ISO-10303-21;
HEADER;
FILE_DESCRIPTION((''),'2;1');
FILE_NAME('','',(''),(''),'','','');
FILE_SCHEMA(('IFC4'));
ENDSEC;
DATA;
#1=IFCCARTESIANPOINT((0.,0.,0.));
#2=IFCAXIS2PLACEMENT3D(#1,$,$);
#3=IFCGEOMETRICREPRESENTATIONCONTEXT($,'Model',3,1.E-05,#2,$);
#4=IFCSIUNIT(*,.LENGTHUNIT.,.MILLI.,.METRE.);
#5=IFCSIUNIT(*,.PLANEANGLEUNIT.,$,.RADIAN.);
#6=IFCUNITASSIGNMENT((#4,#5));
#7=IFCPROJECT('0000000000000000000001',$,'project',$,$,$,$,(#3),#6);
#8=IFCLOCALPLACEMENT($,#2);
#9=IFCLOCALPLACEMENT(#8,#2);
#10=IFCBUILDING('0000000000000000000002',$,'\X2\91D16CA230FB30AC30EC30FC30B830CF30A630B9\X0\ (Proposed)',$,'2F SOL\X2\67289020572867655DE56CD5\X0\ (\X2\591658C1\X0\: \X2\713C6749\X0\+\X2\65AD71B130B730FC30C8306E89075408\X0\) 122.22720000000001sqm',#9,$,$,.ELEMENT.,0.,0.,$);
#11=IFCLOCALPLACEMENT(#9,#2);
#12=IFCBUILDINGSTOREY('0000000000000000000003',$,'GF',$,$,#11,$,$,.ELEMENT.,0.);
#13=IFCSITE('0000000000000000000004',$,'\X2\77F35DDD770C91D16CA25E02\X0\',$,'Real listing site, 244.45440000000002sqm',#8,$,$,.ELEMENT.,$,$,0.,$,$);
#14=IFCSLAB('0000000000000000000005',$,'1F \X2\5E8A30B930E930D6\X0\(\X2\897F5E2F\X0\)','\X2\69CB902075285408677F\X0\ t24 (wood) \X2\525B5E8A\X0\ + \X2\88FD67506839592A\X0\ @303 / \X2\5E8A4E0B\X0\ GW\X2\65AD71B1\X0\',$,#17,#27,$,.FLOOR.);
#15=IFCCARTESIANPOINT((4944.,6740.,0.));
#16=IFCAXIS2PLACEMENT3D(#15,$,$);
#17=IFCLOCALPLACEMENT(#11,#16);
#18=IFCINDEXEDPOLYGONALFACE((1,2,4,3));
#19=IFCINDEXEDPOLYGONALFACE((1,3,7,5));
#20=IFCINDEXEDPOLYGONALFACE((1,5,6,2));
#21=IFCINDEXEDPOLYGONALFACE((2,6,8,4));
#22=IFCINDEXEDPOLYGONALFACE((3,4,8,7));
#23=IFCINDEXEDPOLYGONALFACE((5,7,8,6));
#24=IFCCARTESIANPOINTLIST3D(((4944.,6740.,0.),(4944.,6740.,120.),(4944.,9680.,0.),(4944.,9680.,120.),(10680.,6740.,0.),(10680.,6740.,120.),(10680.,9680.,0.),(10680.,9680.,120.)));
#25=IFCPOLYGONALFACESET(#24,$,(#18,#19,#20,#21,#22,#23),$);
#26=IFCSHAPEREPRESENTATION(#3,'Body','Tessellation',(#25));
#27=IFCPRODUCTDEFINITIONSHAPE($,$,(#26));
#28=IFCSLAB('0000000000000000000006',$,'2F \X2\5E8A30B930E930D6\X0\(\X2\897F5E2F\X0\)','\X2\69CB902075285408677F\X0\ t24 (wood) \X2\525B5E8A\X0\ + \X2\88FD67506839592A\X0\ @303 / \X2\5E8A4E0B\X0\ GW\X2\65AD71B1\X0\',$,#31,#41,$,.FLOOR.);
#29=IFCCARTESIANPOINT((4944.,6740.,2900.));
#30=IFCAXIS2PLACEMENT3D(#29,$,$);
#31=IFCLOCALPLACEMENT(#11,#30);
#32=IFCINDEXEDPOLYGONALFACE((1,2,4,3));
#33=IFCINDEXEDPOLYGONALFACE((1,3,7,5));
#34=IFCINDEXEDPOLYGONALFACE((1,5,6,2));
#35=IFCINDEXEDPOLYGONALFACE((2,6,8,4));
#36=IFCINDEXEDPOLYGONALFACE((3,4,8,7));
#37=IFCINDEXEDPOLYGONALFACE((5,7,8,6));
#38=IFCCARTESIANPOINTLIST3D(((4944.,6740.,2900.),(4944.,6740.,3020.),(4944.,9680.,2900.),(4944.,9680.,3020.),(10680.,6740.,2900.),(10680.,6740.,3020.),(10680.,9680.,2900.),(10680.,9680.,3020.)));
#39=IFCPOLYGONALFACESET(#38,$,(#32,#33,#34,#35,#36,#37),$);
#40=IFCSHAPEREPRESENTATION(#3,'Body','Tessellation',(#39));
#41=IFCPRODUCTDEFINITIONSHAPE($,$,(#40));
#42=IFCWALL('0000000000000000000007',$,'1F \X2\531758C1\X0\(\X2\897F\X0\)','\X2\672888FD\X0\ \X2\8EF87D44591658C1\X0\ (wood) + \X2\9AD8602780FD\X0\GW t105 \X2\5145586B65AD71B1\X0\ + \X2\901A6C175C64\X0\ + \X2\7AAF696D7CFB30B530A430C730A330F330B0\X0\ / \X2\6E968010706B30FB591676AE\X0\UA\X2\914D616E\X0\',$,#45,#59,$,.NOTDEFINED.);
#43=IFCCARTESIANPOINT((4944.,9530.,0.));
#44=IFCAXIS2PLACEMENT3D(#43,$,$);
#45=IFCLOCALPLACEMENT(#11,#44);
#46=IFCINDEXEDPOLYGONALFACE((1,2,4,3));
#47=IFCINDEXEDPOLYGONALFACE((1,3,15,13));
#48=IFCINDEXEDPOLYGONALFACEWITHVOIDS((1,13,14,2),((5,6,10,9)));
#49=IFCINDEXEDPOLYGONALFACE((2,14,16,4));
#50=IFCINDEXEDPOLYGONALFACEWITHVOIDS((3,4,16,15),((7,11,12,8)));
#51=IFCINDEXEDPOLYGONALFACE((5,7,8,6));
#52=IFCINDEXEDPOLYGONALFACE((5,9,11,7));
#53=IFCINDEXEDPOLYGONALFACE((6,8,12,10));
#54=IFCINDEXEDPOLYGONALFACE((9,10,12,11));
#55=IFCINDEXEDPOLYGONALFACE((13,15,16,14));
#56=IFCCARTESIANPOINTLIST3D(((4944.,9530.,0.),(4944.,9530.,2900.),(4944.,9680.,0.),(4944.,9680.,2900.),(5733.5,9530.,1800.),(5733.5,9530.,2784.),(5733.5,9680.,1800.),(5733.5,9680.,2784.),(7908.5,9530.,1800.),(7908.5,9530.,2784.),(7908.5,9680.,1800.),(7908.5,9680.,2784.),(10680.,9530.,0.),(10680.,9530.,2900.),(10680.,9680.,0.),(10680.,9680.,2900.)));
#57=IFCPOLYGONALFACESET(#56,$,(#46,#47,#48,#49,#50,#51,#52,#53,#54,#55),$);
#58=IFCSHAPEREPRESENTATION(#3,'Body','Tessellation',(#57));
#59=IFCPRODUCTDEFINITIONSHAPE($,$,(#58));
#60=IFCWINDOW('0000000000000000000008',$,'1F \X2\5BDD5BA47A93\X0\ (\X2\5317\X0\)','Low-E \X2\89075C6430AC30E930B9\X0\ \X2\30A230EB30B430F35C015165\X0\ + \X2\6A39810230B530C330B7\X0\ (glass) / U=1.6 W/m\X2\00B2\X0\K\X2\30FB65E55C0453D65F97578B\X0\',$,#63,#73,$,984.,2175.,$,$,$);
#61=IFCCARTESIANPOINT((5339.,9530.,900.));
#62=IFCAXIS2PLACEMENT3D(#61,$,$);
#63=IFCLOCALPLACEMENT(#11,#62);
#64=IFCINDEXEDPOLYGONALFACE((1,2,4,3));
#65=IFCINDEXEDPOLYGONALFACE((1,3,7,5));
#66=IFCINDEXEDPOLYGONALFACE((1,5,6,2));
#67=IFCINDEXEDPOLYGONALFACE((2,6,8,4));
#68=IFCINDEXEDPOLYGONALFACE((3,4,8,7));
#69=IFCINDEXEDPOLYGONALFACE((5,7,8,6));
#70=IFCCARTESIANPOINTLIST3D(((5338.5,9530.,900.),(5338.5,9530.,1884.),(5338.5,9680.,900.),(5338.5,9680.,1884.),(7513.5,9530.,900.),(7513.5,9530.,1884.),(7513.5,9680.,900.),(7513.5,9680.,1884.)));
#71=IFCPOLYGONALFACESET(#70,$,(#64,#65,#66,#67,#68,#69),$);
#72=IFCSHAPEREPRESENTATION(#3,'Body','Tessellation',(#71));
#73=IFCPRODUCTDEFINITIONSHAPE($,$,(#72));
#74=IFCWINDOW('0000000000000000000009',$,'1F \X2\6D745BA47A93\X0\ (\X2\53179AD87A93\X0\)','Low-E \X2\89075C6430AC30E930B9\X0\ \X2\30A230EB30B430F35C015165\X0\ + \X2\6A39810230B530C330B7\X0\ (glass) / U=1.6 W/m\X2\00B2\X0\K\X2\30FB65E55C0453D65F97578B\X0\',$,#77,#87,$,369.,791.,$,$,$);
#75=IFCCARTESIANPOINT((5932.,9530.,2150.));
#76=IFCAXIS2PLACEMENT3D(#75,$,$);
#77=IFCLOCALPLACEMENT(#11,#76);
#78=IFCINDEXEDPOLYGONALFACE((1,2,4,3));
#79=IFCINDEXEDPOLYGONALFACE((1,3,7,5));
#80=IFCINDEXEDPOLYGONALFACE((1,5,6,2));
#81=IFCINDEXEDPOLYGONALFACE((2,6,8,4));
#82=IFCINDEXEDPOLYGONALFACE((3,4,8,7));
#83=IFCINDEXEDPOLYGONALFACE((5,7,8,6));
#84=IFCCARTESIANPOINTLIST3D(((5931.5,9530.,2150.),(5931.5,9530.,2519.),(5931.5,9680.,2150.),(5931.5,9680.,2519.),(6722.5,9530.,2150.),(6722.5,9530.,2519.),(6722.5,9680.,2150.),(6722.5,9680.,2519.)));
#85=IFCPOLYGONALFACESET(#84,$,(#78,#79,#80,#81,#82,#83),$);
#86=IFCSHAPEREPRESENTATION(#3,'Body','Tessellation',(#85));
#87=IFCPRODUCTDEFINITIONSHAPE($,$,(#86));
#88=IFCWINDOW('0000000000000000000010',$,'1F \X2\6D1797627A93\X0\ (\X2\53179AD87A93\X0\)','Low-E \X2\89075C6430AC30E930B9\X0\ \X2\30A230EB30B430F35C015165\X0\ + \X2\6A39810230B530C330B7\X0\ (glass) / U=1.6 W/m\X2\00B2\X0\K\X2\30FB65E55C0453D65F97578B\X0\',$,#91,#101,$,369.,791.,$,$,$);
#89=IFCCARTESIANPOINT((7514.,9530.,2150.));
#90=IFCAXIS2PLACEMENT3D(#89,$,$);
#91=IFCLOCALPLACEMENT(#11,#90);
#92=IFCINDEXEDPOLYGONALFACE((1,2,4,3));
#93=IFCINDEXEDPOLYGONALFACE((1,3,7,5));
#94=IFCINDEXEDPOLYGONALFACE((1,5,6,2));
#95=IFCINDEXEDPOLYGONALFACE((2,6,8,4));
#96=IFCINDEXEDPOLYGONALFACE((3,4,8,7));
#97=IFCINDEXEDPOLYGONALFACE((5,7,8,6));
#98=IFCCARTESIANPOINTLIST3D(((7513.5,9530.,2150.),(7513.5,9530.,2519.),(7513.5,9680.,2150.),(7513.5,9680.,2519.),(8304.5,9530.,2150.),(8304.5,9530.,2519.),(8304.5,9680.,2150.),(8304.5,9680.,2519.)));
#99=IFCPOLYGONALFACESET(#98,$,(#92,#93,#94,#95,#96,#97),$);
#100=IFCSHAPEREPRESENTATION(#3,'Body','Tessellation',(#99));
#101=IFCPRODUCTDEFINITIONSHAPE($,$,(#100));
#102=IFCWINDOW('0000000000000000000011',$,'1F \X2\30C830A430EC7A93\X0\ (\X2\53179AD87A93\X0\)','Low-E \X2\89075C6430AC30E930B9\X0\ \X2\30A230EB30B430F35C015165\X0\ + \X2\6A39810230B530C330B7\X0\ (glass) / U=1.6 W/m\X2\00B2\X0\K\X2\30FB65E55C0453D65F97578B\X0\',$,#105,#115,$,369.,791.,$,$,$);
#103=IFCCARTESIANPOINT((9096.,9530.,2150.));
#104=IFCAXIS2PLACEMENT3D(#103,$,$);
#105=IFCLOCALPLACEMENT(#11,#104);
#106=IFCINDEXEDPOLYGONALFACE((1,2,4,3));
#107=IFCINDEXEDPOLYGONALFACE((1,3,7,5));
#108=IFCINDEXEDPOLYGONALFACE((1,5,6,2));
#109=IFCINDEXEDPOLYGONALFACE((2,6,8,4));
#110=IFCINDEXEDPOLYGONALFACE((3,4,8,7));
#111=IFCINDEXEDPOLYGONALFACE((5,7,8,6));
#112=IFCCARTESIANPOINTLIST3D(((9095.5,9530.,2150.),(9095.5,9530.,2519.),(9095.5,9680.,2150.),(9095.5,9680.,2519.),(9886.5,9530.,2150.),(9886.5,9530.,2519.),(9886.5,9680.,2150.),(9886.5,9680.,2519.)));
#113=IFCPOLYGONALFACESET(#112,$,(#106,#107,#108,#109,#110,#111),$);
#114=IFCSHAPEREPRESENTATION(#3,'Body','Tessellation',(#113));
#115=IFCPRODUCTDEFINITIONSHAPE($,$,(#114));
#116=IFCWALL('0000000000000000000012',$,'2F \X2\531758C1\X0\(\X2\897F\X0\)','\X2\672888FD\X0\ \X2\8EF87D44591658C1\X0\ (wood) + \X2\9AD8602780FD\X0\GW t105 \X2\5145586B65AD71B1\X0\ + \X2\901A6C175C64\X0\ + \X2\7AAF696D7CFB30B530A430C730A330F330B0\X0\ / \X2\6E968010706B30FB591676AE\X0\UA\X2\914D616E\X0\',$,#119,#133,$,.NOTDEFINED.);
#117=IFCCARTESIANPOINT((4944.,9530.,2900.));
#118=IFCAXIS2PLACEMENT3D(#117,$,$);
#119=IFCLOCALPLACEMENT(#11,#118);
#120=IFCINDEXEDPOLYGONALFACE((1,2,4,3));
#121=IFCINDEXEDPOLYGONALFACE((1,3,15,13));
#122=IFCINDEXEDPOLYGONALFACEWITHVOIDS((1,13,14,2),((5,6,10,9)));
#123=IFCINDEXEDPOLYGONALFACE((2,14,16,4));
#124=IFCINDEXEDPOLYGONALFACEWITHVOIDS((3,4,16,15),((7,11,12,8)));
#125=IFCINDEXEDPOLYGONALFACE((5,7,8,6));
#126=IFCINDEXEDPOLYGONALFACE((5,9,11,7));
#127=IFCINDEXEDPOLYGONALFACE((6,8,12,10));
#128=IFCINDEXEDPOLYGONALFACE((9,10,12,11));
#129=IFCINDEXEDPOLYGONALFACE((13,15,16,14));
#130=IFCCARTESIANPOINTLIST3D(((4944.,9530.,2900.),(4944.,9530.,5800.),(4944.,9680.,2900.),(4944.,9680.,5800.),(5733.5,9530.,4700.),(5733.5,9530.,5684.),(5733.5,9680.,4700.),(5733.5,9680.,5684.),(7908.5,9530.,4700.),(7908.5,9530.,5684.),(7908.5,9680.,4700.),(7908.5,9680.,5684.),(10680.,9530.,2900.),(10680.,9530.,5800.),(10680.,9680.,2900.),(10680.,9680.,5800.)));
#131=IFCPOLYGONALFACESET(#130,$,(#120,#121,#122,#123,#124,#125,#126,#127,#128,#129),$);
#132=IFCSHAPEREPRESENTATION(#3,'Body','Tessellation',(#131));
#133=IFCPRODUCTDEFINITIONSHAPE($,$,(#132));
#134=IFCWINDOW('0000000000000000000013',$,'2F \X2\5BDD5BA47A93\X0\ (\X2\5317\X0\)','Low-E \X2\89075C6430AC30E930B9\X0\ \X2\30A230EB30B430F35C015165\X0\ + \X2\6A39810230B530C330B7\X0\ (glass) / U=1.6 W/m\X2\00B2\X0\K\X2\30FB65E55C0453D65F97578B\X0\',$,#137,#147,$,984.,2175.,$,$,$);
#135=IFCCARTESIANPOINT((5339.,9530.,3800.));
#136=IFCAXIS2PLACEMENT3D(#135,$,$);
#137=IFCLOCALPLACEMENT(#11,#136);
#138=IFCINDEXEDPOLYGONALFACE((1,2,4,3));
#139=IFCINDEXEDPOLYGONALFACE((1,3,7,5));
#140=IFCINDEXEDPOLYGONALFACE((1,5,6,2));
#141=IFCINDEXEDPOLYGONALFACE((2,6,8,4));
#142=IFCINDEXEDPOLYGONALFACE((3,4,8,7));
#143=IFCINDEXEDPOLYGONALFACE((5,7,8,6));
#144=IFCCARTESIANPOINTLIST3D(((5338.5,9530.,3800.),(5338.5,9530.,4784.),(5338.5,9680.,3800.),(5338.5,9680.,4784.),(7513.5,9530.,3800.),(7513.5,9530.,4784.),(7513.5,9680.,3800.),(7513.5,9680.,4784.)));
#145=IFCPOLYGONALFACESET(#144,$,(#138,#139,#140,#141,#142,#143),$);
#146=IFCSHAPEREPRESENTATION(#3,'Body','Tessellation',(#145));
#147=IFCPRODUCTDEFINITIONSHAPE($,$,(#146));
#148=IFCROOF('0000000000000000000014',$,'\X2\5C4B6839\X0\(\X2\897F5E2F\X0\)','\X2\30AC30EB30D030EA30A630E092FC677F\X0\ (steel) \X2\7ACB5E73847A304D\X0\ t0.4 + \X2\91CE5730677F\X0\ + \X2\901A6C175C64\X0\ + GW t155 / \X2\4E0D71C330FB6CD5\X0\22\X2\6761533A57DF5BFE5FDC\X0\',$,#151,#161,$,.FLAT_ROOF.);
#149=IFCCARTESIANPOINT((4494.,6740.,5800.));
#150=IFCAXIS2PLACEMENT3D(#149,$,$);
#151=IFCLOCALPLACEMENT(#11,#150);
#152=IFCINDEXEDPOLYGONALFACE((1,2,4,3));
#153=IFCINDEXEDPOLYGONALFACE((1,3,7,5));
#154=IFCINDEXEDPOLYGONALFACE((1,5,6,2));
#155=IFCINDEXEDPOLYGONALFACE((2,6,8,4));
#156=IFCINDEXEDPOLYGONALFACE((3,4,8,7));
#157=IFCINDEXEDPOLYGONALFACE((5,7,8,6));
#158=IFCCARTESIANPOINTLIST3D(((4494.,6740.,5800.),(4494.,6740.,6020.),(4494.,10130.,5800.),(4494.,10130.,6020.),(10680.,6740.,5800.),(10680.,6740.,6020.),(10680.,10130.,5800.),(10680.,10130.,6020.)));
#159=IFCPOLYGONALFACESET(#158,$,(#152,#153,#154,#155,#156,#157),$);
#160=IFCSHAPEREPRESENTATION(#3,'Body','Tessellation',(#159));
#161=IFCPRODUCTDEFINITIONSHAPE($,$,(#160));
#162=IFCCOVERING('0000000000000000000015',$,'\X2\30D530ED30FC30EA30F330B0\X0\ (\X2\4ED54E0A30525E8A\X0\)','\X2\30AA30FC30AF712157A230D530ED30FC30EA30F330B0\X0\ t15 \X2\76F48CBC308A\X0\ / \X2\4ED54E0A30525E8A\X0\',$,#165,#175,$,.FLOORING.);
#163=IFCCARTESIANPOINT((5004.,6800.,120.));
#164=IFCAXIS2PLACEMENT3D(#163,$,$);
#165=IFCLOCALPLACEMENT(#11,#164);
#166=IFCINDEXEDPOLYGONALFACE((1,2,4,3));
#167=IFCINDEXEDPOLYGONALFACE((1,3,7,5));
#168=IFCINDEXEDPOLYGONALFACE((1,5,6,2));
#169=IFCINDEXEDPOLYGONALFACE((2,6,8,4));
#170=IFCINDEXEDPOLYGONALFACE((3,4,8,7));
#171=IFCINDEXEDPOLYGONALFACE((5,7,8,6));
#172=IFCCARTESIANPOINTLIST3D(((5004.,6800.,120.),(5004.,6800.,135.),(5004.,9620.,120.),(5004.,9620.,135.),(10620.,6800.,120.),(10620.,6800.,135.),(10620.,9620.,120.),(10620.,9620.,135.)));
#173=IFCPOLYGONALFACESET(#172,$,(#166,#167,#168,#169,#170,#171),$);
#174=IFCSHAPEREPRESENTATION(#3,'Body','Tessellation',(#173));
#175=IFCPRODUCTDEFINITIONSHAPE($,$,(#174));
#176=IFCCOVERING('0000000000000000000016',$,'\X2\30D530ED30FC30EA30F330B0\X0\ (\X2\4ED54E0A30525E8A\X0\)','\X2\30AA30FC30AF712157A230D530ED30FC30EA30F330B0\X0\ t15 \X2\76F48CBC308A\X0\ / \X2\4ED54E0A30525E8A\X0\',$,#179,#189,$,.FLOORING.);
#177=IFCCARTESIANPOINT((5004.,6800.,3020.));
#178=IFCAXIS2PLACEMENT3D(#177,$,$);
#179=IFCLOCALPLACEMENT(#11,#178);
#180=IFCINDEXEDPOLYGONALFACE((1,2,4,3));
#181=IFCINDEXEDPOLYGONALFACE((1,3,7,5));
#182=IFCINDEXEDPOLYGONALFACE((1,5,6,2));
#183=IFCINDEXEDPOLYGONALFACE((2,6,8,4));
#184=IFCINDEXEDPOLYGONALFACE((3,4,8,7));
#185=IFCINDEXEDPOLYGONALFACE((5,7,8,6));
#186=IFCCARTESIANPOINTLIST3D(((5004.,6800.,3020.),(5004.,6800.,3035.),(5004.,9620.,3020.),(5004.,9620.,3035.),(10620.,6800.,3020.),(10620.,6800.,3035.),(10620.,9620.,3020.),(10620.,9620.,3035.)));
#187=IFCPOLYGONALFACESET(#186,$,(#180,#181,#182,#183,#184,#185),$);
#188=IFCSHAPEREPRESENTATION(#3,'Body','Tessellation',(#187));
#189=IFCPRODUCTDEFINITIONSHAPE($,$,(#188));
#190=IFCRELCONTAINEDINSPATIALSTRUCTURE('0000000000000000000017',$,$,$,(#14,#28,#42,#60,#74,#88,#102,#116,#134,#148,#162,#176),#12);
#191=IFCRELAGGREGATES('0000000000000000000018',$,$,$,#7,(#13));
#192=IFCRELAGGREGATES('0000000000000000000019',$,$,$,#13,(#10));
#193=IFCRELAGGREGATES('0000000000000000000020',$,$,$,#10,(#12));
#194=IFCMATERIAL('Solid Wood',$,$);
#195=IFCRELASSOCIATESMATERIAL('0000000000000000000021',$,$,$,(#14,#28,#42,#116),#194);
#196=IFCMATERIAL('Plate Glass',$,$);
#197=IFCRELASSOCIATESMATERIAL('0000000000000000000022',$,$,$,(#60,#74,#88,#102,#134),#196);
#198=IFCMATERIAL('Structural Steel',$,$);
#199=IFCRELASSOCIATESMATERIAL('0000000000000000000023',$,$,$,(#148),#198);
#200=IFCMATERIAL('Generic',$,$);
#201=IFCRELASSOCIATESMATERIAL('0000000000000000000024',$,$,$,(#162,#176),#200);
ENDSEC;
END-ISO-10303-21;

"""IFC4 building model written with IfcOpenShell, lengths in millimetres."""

from ifc_helpers import new_model, si_unit, frame, frame_2d, origin, place, context, project, spatial, rectangle, extrude, material, element, fill, save


model = new_model("IFC4")

# Units and contexts
model_context = context("Model", 3, precision=1e-05, world=origin())
ifc_project = project(units=[si_unit("LENGTHUNIT", "METRE", prefix="MILLI"), si_unit("PLANEANGLEUNIT", "RADIAN")], contexts=[model_context])

# Site, building, storey
site_placement = place(None, origin())
site = spatial("IfcSite", under=ifc_project, at=site_placement, Name="石川県金沢市", ObjectType="Real listing site, 244.45440000000002sqm", CompositionType="ELEMENT", RefElevation=0.0)
building_placement = place(site_placement, origin())
building = spatial("IfcBuilding", under=site, at=building_placement, Name="金沢・ガレージハウス (Proposed)", ObjectType="2F SOL木造在来工法 (外壁: 焼杉+断熱シートの複合) 122.22720000000001sqm", CompositionType="ELEMENT", ElevationOfRefHeight=0.0, ElevationOfTerrain=0.0)
storey_placement = place(building_placement, origin())
storey = spatial("IfcBuildingStorey", under=building, at=storey_placement, Name="GF", CompositionType="ELEMENT", Elevation=0.0)

# Slabs
ifc_material_1 = material(Name="Solid Wood")
slab_1_placement = place(storey_placement, frame((4944.0, 6740.0, 0.0)))
element("IfcSlab", 1, at=slab_1_placement, inside=storey, material=ifc_material_1, Name="1F 床スラブ(西帯)", Description="構造用合板 t24 (wood) 剛床 + 製材根太 @303 / 床下 GW断熱", PredefinedType="FLOOR", context=model_context, shape_type="SweptSolid", body=[
    extrude(rectangle(XDim=5736.0, YDim=2940.0, at=frame_2d((2868.0, 1470.0))), frame((4944.0, 6740.0, 0.0)), (0.0, 0.0, 1.0), 120.0),
])
slab_2_placement = place(storey_placement, frame((4944.0, 6740.0, 2900.0)))
element("IfcSlab", 2, at=slab_2_placement, inside=storey, material=ifc_material_1, Name="2F 床スラブ(西帯)", Description="構造用合板 t24 (wood) 剛床 + 製材根太 @303 / 床下 GW断熱", PredefinedType="FLOOR", context=model_context, shape_type="SweptSolid", body=[
    extrude(rectangle(XDim=5736.0, YDim=2940.0, at=frame_2d((2868.0, 1470.0))), frame((4944.0, 6740.0, 2900.0)), (0.0, 0.0, 1.0), 120.0),
])

# Wall, openings, windows
wall_1_placement = place(storey_placement, frame((4944.0, 9530.0, 0.0)))
wall_1 = element("IfcWall", 3, at=wall_1_placement, inside=storey, material=ifc_material_1, Name="1F 北壁(西)", Description="木製 軸組外壁 (wood) + 高性能GW t105 充填断熱 + 通気層 + 窯業系サイディング / 準耐火・外皮UA配慮", PredefinedType="NOTDEFINED", context=model_context, shape_type="SweptSolid", body=[
    extrude(rectangle(XDim=5736.0, YDim=150.0, at=frame_2d((2868.0, 75.0))), frame((4944.0, 9530.0, 0.0)), (0.0, 0.0, 1.0), 2900.0),
])
opening_1_placement = place(storey_placement, frame((5339.0, 9530.0, 900.0)))
opening_1 = element("IfcOpeningElement", 4, at=opening_1_placement, cuts=wall_1, PredefinedType="NOTDEFINED", context=model_context, shape_type="SweptSolid", body=[
    extrude(rectangle(XDim=2175.0, YDim=150.0, at=frame_2d((1087.0, 75.0))), frame((5339.0, 9530.0, 900.0)), (0.0, 0.0, 1.0), 984.0),
])
opening_2_placement = place(storey_placement, frame((5932.0, 9530.0, 2150.0)))
opening_2 = element("IfcOpeningElement", 5, at=opening_2_placement, cuts=wall_1, PredefinedType="NOTDEFINED", context=model_context, shape_type="SweptSolid", body=[
    extrude(rectangle(XDim=791.0, YDim=150.0, at=frame_2d((395.0, 75.0))), frame((5932.0, 9530.0, 2150.0)), (0.0, 0.0, 1.0), 369.0),
])
opening_3_placement = place(storey_placement, frame((7514.0, 9530.0, 2150.0)))
opening_3 = element("IfcOpeningElement", 6, at=opening_3_placement, cuts=wall_1, PredefinedType="NOTDEFINED", context=model_context, shape_type="SweptSolid", body=[
    extrude(rectangle(XDim=791.0, YDim=150.0, at=frame_2d((395.0, 75.0))), frame((7514.0, 9530.0, 2150.0)), (0.0, 0.0, 1.0), 369.0),
])
opening_4_placement = place(storey_placement, frame((9096.0, 9530.0, 2150.0)))
opening_4 = element("IfcOpeningElement", 7, at=opening_4_placement, cuts=wall_1, PredefinedType="NOTDEFINED", context=model_context, shape_type="SweptSolid", body=[
    extrude(rectangle(XDim=791.0, YDim=150.0, at=frame_2d((395.0, 75.0))), frame((9096.0, 9530.0, 2150.0)), (0.0, 0.0, 1.0), 369.0),
])
ifc_material_2 = material(Name="Plate Glass")
window_1_placement = place(storey_placement, frame((5339.0, 9530.0, 900.0)))
window_1 = element("IfcWindow", 8, at=window_1_placement, inside=storey, material=ifc_material_2, Name="1F 寝室窓 (北)", Description="Low-E 複層ガラス アルゴン封入 + 樹脂サッシ (glass) / U=1.6 W/m²K・日射取得型", OverallHeight=984.0, OverallWidth=2175.0, context=model_context, shape_type="SweptSolid", body=[
    extrude(rectangle(XDim=2175.0, YDim=150.0, at=frame_2d((1087.0, 75.0))), frame((5339.0, 9530.0, 900.0)), (0.0, 0.0, 1.0), 984.0),
])
fill(opening_1, window_1)
window_2_placement = place(storey_placement, frame((5932.0, 9530.0, 2150.0)))
window_2 = element("IfcWindow", 9, at=window_2_placement, inside=storey, material=ifc_material_2, Name="1F 浴室窓 (北高窓)", Description="Low-E 複層ガラス アルゴン封入 + 樹脂サッシ (glass) / U=1.6 W/m²K・日射取得型", OverallHeight=369.0, OverallWidth=791.0, context=model_context, shape_type="SweptSolid", body=[
    extrude(rectangle(XDim=791.0, YDim=150.0, at=frame_2d((395.0, 75.0))), frame((5932.0, 9530.0, 2150.0)), (0.0, 0.0, 1.0), 369.0),
])
fill(opening_2, window_2)
window_3_placement = place(storey_placement, frame((7514.0, 9530.0, 2150.0)))
window_3 = element("IfcWindow", 10, at=window_3_placement, inside=storey, material=ifc_material_2, Name="1F 洗面窓 (北高窓)", Description="Low-E 複層ガラス アルゴン封入 + 樹脂サッシ (glass) / U=1.6 W/m²K・日射取得型", OverallHeight=369.0, OverallWidth=791.0, context=model_context, shape_type="SweptSolid", body=[
    extrude(rectangle(XDim=791.0, YDim=150.0, at=frame_2d((395.0, 75.0))), frame((7514.0, 9530.0, 2150.0)), (0.0, 0.0, 1.0), 369.0),
])
fill(opening_3, window_3)
window_4_placement = place(storey_placement, frame((9096.0, 9530.0, 2150.0)))
window_4 = element("IfcWindow", 11, at=window_4_placement, inside=storey, material=ifc_material_2, Name="1F トイレ窓 (北高窓)", Description="Low-E 複層ガラス アルゴン封入 + 樹脂サッシ (glass) / U=1.6 W/m²K・日射取得型", OverallHeight=369.0, OverallWidth=791.0, context=model_context, shape_type="SweptSolid", body=[
    extrude(rectangle(XDim=791.0, YDim=150.0, at=frame_2d((395.0, 75.0))), frame((9096.0, 9530.0, 2150.0)), (0.0, 0.0, 1.0), 369.0),
])
fill(opening_4, window_4)

# Wall, opening, window
wall_2_placement = place(storey_placement, frame((4944.0, 9530.0, 2900.0)))
wall_2 = element("IfcWall", 12, at=wall_2_placement, inside=storey, material=ifc_material_1, Name="2F 北壁(西)", Description="木製 軸組外壁 (wood) + 高性能GW t105 充填断熱 + 通気層 + 窯業系サイディング / 準耐火・外皮UA配慮", PredefinedType="NOTDEFINED", context=model_context, shape_type="SweptSolid", body=[
    extrude(rectangle(XDim=5736.0, YDim=150.0, at=frame_2d((2868.0, 75.0))), frame((4944.0, 9530.0, 2900.0)), (0.0, 0.0, 1.0), 2900.0),
])
opening_5_placement = place(storey_placement, frame((5339.0, 9530.0, 3800.0)))
opening_5 = element("IfcOpeningElement", 13, at=opening_5_placement, cuts=wall_2, PredefinedType="NOTDEFINED", context=model_context, shape_type="SweptSolid", body=[
    extrude(rectangle(XDim=2175.0, YDim=150.0, at=frame_2d((1087.0, 75.0))), frame((5339.0, 9530.0, 3800.0)), (0.0, 0.0, 1.0), 984.0),
])
window_5_placement = place(storey_placement, frame((5339.0, 9530.0, 3800.0)))
window_5 = element("IfcWindow", 14, at=window_5_placement, inside=storey, material=ifc_material_2, Name="2F 寝室窓 (北)", Description="Low-E 複層ガラス アルゴン封入 + 樹脂サッシ (glass) / U=1.6 W/m²K・日射取得型", OverallHeight=984.0, OverallWidth=2175.0, context=model_context, shape_type="SweptSolid", body=[
    extrude(rectangle(XDim=2175.0, YDim=150.0, at=frame_2d((1087.0, 75.0))), frame((5339.0, 9530.0, 3800.0)), (0.0, 0.0, 1.0), 984.0),
])
fill(opening_5, window_5)

# Roof
ifc_material_3 = material(Name="Structural Steel")
for number, where, name in (
    (15, (4494.0, 6740.0, 5800.0), "屋根(西帯)"),
):
    element("IfcRoof", number, at=place(storey_placement, frame(where)), inside=storey, material=ifc_material_3, Name=name, Description="ガルバリウム鋼板 (steel) 立平葺き t0.4 + 野地板 + 通気層 + GW t155 / 不燃・法22条区域対応", PredefinedType="FLAT_ROOF", context=model_context, shape_type="SweptSolid", body=[
        extrude(rectangle(XDim=6186.0, YDim=3390.0, at=frame_2d((3093.0, 1695.0))), frame((4494.0, 6740.0, 5800.0)), (0.0, 0.0, 1.0), 220.0),
    ])

# Coverings
ifc_material_4 = material(Name="Generic")
covering_1_placement = place(storey_placement, frame((5004.0, 6800.0, 120.0)))
element("IfcCovering", 16, at=covering_1_placement, inside=storey, material=ifc_material_4, Name="フローリング (仕上げ床)", Description="オーク無垢フローリング t15 直貼り / 仕上げ床", PredefinedType="FLOORING", context=model_context, shape_type="SweptSolid", body=[
    extrude(rectangle(XDim=5616.0, YDim=2820.0, at=frame_2d((2808.0, 1410.0))), frame((5004.0, 6800.0, 120.0)), (0.0, 0.0, 1.0), 15.0),
])
covering_2_placement = place(storey_placement, frame((5004.0, 6800.0, 3020.0)))
element("IfcCovering", 17, at=covering_2_placement, inside=storey, material=ifc_material_4, Name="フローリング (仕上げ床)", Description="オーク無垢フローリング t15 直貼り / 仕上げ床", PredefinedType="FLOORING", context=model_context, shape_type="SweptSolid", body=[
    extrude(rectangle(XDim=5616.0, YDim=2820.0, at=frame_2d((2808.0, 1410.0))), frame((5004.0, 6800.0, 3020.0)), (0.0, 0.0, 1.0), 15.0),
])

save(model, "model.ifc")
